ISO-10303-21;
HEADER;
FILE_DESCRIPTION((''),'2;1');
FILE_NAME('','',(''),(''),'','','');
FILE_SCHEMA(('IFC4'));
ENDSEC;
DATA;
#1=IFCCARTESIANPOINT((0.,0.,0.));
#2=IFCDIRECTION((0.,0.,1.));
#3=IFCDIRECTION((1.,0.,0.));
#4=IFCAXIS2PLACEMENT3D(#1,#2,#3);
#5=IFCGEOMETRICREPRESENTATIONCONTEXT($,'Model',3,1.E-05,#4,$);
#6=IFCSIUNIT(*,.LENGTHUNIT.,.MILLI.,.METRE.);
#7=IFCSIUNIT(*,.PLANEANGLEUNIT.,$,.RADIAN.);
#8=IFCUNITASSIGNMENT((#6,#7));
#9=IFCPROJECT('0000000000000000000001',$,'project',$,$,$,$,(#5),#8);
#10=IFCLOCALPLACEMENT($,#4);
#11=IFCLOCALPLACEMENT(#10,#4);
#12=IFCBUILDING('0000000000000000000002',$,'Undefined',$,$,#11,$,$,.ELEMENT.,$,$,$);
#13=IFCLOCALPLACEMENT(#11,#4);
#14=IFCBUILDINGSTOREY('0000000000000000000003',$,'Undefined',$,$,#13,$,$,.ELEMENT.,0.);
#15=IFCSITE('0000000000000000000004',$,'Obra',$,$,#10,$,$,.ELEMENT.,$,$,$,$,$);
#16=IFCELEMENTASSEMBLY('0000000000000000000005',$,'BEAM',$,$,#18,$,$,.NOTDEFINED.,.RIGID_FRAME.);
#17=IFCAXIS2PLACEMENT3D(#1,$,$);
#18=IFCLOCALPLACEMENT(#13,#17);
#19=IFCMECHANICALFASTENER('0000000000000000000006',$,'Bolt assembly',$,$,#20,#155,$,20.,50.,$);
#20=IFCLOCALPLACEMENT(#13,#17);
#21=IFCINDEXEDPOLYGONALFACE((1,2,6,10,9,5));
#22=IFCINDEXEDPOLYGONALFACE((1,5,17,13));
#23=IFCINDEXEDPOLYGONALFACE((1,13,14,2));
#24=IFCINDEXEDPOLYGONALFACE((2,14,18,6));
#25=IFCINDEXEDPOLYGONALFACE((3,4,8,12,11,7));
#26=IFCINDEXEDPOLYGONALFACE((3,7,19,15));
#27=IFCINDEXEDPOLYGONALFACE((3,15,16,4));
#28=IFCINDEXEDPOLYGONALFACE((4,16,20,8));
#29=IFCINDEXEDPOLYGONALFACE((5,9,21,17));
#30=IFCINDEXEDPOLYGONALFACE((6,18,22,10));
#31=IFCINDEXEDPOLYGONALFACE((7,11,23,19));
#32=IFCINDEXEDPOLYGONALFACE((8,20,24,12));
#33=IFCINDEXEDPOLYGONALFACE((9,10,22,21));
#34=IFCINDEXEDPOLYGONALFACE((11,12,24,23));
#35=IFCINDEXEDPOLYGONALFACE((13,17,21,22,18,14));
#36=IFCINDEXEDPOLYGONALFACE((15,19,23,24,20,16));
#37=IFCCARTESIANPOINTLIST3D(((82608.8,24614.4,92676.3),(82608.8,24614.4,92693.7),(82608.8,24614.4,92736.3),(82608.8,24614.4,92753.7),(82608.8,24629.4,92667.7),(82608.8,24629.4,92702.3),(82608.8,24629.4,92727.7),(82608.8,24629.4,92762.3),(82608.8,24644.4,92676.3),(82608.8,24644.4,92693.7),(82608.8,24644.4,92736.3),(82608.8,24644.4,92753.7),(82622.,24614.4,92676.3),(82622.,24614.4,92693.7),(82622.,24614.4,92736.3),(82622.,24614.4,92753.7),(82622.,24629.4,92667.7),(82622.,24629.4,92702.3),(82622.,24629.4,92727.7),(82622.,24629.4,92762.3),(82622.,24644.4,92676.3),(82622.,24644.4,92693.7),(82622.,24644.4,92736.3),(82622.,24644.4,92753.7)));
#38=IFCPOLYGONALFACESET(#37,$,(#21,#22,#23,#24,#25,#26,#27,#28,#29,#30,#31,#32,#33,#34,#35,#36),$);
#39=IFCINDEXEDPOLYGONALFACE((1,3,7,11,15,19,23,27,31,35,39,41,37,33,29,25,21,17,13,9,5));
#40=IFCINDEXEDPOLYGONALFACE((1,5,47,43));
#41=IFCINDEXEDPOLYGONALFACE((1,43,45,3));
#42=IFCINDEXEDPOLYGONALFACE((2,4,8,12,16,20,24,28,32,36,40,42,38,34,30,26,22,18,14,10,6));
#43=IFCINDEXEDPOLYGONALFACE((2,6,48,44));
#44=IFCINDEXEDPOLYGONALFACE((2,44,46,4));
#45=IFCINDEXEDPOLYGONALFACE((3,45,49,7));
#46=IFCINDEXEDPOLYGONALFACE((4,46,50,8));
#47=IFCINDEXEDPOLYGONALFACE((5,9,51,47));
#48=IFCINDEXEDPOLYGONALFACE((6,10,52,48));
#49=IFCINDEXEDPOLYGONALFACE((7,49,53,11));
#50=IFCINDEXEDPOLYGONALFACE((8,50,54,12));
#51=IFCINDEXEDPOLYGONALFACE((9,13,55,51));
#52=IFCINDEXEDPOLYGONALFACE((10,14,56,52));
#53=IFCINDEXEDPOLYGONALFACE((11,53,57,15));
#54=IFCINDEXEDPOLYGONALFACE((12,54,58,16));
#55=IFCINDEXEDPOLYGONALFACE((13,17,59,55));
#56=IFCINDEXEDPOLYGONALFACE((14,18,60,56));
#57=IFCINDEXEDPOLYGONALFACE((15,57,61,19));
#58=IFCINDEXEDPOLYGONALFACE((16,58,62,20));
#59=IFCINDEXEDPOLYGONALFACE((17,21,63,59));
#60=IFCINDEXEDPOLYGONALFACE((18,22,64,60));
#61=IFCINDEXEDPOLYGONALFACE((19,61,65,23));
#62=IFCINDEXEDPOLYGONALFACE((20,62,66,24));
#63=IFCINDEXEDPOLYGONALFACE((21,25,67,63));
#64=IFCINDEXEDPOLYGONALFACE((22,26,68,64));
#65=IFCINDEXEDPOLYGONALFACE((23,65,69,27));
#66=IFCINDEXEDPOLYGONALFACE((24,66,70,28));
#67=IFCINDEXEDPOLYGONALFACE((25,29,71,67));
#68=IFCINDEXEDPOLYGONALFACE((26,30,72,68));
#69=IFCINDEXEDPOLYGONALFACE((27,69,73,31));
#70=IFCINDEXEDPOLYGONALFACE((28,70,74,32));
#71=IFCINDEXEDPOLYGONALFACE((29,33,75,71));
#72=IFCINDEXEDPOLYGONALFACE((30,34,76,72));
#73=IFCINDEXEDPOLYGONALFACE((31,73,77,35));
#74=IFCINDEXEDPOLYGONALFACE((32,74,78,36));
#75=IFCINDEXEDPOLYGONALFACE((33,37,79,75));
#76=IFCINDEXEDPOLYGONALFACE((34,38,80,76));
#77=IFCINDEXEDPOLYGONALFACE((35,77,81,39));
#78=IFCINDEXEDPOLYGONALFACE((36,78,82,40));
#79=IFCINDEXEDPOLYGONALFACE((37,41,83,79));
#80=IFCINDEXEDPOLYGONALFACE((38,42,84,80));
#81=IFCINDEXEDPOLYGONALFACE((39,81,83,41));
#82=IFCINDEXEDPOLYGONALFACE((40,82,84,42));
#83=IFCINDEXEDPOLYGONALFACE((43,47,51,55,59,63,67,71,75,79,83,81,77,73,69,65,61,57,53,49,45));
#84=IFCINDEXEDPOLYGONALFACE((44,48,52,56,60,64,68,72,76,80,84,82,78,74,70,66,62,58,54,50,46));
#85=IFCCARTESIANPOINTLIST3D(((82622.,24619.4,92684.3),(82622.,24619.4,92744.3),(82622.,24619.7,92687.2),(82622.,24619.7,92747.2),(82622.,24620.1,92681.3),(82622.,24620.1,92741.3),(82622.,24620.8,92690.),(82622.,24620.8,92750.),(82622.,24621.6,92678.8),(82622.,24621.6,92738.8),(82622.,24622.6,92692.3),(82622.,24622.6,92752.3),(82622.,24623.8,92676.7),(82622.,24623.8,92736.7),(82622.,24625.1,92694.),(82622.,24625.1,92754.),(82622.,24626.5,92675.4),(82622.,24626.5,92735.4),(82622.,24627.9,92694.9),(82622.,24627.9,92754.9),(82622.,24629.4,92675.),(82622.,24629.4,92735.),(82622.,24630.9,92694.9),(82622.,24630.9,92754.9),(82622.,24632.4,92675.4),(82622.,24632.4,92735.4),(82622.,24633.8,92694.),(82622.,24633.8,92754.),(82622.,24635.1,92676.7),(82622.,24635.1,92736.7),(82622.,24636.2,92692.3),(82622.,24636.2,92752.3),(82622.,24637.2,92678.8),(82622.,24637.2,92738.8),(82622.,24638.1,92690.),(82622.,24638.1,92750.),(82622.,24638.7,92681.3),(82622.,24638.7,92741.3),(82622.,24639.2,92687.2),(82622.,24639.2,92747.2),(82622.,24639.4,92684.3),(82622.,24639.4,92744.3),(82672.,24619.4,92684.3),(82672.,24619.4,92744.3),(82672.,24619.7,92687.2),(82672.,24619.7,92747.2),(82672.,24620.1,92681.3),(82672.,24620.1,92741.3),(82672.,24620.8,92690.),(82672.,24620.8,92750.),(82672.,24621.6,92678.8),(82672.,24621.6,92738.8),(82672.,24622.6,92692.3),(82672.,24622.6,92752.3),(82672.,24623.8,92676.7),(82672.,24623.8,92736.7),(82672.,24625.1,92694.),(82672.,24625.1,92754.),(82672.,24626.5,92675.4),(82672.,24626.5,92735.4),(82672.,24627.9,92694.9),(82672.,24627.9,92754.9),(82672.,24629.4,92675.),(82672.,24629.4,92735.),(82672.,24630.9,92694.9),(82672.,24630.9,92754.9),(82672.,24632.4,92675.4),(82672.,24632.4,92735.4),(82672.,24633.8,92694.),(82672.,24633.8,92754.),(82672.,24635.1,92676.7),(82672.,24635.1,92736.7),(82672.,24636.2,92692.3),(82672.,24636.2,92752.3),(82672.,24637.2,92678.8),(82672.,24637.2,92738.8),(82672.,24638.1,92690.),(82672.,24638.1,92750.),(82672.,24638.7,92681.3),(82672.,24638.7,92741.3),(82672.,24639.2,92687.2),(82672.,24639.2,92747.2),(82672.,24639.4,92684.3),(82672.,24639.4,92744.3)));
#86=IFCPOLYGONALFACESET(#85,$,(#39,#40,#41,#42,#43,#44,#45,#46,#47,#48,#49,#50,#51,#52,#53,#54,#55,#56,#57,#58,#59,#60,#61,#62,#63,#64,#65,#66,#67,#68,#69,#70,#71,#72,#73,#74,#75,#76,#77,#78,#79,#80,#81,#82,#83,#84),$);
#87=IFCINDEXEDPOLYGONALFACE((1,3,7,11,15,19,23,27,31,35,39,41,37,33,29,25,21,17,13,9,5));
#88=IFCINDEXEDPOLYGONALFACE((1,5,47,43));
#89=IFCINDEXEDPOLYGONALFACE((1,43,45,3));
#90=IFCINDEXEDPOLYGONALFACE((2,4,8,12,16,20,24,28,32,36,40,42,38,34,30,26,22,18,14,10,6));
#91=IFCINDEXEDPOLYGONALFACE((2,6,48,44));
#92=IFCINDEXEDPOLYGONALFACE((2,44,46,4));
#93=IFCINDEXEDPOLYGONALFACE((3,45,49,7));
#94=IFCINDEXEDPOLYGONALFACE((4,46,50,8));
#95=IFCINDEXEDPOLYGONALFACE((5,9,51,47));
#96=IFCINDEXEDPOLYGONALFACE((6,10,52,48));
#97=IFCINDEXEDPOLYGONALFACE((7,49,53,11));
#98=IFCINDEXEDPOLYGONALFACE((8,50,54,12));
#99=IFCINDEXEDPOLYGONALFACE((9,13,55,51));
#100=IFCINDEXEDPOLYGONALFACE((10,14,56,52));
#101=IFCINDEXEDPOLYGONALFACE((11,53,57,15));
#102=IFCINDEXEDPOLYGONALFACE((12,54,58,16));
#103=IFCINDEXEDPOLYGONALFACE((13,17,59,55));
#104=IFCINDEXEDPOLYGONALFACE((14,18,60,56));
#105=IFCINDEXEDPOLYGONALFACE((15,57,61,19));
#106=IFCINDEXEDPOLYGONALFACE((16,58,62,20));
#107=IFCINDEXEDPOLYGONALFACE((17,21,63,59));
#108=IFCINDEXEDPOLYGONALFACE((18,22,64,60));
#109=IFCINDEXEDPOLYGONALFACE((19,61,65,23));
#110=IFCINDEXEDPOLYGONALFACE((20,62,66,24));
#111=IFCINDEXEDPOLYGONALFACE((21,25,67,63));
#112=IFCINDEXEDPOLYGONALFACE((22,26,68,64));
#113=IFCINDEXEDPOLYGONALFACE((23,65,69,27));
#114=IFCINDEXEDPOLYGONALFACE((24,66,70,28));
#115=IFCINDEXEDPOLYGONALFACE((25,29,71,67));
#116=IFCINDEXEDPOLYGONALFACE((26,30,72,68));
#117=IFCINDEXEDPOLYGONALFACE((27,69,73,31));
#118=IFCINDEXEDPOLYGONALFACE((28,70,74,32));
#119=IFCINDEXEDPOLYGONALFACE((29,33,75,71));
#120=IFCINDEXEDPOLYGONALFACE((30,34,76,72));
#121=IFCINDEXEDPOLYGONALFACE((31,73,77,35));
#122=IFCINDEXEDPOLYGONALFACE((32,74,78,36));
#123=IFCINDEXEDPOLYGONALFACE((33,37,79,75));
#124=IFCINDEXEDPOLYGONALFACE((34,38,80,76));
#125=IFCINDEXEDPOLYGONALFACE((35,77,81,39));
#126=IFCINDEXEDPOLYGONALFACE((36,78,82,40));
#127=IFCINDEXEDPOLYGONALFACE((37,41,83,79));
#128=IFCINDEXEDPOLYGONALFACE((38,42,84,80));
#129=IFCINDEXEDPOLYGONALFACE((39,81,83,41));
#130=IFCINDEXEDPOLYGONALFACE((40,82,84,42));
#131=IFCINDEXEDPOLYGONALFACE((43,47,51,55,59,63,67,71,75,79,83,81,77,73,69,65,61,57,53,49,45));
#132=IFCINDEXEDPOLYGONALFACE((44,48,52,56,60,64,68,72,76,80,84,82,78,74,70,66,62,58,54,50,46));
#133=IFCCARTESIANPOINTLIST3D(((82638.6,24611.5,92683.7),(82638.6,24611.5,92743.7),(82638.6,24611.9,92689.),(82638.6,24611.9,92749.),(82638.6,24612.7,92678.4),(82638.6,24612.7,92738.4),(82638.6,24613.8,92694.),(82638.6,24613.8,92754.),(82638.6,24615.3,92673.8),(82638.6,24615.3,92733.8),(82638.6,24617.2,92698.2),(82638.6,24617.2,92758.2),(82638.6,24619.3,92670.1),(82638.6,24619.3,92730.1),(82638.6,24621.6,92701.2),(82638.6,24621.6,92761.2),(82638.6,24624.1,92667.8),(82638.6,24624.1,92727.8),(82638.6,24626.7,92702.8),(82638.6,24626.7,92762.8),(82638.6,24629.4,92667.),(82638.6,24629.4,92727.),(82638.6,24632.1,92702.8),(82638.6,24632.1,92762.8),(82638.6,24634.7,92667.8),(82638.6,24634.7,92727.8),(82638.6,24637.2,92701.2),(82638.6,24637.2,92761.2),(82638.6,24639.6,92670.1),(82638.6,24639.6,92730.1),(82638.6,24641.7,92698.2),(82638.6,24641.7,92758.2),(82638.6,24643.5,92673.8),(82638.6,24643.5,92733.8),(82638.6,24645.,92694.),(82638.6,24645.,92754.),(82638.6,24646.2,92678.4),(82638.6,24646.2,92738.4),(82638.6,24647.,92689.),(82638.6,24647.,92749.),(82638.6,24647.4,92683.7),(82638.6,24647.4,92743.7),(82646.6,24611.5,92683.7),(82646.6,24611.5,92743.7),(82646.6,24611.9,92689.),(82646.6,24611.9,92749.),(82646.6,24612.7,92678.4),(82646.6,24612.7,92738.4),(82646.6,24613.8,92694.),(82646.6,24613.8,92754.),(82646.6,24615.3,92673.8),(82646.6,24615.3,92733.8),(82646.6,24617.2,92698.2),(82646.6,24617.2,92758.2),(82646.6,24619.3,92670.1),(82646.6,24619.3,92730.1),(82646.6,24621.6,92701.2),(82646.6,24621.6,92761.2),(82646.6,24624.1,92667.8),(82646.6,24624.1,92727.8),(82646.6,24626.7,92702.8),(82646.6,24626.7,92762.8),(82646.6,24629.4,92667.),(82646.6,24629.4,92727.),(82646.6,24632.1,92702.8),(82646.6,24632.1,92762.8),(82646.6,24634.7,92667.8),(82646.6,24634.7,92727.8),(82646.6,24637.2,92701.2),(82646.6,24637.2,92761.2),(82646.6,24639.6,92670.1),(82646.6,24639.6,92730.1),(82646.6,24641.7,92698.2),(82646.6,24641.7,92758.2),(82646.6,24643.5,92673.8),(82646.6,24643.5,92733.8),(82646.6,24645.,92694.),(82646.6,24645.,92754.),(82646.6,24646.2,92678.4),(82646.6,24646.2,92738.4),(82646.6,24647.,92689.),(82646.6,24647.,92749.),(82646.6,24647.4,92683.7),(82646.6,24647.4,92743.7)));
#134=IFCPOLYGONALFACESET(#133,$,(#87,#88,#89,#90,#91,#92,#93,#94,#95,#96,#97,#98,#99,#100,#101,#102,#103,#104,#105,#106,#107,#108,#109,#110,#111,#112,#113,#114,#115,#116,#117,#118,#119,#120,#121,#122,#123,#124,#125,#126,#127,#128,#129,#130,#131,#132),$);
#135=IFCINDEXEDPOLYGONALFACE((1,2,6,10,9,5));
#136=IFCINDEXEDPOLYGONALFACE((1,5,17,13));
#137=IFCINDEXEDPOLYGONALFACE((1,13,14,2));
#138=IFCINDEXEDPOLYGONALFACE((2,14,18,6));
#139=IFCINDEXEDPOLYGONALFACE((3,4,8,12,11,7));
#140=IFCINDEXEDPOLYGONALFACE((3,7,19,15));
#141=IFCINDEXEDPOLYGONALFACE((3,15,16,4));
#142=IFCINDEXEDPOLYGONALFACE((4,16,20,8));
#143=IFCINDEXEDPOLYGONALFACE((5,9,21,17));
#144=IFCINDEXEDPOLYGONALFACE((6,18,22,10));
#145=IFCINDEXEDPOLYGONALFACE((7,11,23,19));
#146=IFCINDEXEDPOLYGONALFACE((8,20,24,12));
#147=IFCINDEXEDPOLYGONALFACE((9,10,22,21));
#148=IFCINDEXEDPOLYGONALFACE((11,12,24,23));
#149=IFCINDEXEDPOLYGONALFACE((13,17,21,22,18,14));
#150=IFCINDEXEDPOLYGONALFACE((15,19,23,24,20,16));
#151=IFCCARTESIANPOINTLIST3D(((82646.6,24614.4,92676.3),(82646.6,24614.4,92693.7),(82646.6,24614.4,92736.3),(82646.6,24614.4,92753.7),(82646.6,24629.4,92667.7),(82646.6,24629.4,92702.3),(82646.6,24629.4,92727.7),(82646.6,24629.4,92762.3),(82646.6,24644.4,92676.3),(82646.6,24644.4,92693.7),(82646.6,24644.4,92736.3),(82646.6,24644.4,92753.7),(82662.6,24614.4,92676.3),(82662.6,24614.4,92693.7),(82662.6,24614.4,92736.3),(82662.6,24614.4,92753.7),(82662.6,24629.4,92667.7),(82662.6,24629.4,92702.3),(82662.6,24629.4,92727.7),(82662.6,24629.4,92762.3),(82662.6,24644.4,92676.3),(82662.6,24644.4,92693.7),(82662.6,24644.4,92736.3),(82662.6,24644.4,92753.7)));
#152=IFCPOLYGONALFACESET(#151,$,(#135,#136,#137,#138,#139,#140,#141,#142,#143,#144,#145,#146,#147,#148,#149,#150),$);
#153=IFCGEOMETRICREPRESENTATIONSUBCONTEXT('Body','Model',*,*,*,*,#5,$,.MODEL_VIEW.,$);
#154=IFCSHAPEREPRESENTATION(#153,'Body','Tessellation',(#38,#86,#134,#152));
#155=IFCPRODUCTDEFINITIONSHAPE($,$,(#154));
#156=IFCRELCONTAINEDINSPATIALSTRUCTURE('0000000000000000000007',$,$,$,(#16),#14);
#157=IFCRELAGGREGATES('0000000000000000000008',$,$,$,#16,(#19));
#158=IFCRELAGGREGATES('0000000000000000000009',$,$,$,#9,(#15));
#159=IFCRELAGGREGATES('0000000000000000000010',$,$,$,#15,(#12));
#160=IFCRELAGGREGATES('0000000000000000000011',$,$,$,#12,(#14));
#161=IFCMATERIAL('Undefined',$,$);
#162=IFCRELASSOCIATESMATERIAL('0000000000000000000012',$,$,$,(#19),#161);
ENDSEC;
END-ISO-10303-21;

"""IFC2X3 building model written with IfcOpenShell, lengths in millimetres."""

from ifc_helpers import new_model, si_unit, frame, origin_with_axes, origin_2d_with_axis, place, context, subcontext, project, spatial, polyline, circle, outline, extrude, source, transform, mapped, material, element, aggregate, save


model = new_model("IFC2X3")

# Units and contexts
model_context = context("Model", 3, precision=1e-05, world=origin_with_axes())
body_context = subcontext(model_context, "Body", "Model", "MODEL_VIEW")
ifc_project = project(units=[si_unit("LENGTHUNIT", "METRE", prefix="MILLI"), si_unit("PLANEANGLEUNIT", "RADIAN")], contexts=[model_context])

# Site, building, storey
site_placement = place(None, origin_with_axes())
site = spatial("IfcSite", under=ifc_project, at=site_placement, Name="Obra", CompositionType="ELEMENT")
building_placement = place(site_placement, origin_with_axes())
building = spatial("IfcBuilding", under=site, at=building_placement, Name="Undefined", CompositionType="ELEMENT")
storey_placement = place(building_placement, origin_with_axes())
storey = spatial("IfcBuildingStorey", under=building, at=storey_placement, Name="Undefined", CompositionType="ELEMENT", Elevation=0.0)

# Element assembly
assembly_1_placement = place(storey_placement, origin_with_axes())
assembly_1 = element("IfcElementAssembly", 1, at=assembly_1_placement, inside=storey, Name="BEAM", AssemblyPlace="NOTDEFINED", PredefinedType="RIGID_FRAME")
ifc_material_1 = material(Name="Undefined")
shared_shape_1 = source(origin_with_axes(), body_context, "Body", "SweptSolid", [
    extrude(outline(polyline([(17.3, 0.0), (8.7, 15.0), (-8.7, 15.0), (-17.3, 0.0), (-8.7, -15.0), (8.7, -15.0), (17.3, 0.0)])), frame((0.0, -26.5, 0.0), z_axis=(0.0, 1.0, 0.0), x_axis=(1.0, 0.0, 0.0)), (0.0, 0.0, 1.0), 13.2),
    extrude(circle(Radius=10.0, at=origin_2d_with_axis()), frame((0.0, -13.3, 0.0), z_axis=(0.0, 1.0, 0.0), x_axis=(1.0, 0.0, 0.0)), (0.0, 0.0, 1.0), 50.0),
    extrude(circle(Radius=18.0, at=origin_2d_with_axis()), frame((0.0, 3.3, 0.0), z_axis=(0.0, 1.0, 0.0), x_axis=(1.0, 0.0, 0.0)), (0.0, 0.0, 1.0), 8.0),
    extrude(outline(polyline([(17.3, 0.0), (8.7, 15.0), (-8.7, 15.0), (-17.3, 0.0), (-8.7, -15.0), (8.7, -15.0), (17.3, 0.0)])), frame((0.0, 11.3, 0.0), z_axis=(0.0, 1.0, 0.0), x_axis=(1.0, 0.0, 0.0)), (0.0, 0.0, 1.0), 16.0),
])

# Mechanical fastener
mechanical_fastener_1_placement = place(assembly_1_placement, frame((82635.3, 24669.4, 92850.0), z_axis=(0.000002, -1.0, 0.0), x_axis=(0.0, 0.0, -1.0)))
mechanical_fastener_1 = element("IfcMechanicalFastener", 2, at=mechanical_fastener_1_placement, material=ifc_material_1, Name="Bolt assembly", NominalDiameter=20.0, NominalLength=50.0, context=body_context, shape_type="MappedRepresentation", body=[
    mapped(shared_shape_1, transform((105.0, 0.0, 40.0))),
    mapped(shared_shape_1, transform((165.0, 0.0, 40.0))),
])
aggregate(assembly_1, [mechanical_fastener_1])

save(model, "model.ifc")
